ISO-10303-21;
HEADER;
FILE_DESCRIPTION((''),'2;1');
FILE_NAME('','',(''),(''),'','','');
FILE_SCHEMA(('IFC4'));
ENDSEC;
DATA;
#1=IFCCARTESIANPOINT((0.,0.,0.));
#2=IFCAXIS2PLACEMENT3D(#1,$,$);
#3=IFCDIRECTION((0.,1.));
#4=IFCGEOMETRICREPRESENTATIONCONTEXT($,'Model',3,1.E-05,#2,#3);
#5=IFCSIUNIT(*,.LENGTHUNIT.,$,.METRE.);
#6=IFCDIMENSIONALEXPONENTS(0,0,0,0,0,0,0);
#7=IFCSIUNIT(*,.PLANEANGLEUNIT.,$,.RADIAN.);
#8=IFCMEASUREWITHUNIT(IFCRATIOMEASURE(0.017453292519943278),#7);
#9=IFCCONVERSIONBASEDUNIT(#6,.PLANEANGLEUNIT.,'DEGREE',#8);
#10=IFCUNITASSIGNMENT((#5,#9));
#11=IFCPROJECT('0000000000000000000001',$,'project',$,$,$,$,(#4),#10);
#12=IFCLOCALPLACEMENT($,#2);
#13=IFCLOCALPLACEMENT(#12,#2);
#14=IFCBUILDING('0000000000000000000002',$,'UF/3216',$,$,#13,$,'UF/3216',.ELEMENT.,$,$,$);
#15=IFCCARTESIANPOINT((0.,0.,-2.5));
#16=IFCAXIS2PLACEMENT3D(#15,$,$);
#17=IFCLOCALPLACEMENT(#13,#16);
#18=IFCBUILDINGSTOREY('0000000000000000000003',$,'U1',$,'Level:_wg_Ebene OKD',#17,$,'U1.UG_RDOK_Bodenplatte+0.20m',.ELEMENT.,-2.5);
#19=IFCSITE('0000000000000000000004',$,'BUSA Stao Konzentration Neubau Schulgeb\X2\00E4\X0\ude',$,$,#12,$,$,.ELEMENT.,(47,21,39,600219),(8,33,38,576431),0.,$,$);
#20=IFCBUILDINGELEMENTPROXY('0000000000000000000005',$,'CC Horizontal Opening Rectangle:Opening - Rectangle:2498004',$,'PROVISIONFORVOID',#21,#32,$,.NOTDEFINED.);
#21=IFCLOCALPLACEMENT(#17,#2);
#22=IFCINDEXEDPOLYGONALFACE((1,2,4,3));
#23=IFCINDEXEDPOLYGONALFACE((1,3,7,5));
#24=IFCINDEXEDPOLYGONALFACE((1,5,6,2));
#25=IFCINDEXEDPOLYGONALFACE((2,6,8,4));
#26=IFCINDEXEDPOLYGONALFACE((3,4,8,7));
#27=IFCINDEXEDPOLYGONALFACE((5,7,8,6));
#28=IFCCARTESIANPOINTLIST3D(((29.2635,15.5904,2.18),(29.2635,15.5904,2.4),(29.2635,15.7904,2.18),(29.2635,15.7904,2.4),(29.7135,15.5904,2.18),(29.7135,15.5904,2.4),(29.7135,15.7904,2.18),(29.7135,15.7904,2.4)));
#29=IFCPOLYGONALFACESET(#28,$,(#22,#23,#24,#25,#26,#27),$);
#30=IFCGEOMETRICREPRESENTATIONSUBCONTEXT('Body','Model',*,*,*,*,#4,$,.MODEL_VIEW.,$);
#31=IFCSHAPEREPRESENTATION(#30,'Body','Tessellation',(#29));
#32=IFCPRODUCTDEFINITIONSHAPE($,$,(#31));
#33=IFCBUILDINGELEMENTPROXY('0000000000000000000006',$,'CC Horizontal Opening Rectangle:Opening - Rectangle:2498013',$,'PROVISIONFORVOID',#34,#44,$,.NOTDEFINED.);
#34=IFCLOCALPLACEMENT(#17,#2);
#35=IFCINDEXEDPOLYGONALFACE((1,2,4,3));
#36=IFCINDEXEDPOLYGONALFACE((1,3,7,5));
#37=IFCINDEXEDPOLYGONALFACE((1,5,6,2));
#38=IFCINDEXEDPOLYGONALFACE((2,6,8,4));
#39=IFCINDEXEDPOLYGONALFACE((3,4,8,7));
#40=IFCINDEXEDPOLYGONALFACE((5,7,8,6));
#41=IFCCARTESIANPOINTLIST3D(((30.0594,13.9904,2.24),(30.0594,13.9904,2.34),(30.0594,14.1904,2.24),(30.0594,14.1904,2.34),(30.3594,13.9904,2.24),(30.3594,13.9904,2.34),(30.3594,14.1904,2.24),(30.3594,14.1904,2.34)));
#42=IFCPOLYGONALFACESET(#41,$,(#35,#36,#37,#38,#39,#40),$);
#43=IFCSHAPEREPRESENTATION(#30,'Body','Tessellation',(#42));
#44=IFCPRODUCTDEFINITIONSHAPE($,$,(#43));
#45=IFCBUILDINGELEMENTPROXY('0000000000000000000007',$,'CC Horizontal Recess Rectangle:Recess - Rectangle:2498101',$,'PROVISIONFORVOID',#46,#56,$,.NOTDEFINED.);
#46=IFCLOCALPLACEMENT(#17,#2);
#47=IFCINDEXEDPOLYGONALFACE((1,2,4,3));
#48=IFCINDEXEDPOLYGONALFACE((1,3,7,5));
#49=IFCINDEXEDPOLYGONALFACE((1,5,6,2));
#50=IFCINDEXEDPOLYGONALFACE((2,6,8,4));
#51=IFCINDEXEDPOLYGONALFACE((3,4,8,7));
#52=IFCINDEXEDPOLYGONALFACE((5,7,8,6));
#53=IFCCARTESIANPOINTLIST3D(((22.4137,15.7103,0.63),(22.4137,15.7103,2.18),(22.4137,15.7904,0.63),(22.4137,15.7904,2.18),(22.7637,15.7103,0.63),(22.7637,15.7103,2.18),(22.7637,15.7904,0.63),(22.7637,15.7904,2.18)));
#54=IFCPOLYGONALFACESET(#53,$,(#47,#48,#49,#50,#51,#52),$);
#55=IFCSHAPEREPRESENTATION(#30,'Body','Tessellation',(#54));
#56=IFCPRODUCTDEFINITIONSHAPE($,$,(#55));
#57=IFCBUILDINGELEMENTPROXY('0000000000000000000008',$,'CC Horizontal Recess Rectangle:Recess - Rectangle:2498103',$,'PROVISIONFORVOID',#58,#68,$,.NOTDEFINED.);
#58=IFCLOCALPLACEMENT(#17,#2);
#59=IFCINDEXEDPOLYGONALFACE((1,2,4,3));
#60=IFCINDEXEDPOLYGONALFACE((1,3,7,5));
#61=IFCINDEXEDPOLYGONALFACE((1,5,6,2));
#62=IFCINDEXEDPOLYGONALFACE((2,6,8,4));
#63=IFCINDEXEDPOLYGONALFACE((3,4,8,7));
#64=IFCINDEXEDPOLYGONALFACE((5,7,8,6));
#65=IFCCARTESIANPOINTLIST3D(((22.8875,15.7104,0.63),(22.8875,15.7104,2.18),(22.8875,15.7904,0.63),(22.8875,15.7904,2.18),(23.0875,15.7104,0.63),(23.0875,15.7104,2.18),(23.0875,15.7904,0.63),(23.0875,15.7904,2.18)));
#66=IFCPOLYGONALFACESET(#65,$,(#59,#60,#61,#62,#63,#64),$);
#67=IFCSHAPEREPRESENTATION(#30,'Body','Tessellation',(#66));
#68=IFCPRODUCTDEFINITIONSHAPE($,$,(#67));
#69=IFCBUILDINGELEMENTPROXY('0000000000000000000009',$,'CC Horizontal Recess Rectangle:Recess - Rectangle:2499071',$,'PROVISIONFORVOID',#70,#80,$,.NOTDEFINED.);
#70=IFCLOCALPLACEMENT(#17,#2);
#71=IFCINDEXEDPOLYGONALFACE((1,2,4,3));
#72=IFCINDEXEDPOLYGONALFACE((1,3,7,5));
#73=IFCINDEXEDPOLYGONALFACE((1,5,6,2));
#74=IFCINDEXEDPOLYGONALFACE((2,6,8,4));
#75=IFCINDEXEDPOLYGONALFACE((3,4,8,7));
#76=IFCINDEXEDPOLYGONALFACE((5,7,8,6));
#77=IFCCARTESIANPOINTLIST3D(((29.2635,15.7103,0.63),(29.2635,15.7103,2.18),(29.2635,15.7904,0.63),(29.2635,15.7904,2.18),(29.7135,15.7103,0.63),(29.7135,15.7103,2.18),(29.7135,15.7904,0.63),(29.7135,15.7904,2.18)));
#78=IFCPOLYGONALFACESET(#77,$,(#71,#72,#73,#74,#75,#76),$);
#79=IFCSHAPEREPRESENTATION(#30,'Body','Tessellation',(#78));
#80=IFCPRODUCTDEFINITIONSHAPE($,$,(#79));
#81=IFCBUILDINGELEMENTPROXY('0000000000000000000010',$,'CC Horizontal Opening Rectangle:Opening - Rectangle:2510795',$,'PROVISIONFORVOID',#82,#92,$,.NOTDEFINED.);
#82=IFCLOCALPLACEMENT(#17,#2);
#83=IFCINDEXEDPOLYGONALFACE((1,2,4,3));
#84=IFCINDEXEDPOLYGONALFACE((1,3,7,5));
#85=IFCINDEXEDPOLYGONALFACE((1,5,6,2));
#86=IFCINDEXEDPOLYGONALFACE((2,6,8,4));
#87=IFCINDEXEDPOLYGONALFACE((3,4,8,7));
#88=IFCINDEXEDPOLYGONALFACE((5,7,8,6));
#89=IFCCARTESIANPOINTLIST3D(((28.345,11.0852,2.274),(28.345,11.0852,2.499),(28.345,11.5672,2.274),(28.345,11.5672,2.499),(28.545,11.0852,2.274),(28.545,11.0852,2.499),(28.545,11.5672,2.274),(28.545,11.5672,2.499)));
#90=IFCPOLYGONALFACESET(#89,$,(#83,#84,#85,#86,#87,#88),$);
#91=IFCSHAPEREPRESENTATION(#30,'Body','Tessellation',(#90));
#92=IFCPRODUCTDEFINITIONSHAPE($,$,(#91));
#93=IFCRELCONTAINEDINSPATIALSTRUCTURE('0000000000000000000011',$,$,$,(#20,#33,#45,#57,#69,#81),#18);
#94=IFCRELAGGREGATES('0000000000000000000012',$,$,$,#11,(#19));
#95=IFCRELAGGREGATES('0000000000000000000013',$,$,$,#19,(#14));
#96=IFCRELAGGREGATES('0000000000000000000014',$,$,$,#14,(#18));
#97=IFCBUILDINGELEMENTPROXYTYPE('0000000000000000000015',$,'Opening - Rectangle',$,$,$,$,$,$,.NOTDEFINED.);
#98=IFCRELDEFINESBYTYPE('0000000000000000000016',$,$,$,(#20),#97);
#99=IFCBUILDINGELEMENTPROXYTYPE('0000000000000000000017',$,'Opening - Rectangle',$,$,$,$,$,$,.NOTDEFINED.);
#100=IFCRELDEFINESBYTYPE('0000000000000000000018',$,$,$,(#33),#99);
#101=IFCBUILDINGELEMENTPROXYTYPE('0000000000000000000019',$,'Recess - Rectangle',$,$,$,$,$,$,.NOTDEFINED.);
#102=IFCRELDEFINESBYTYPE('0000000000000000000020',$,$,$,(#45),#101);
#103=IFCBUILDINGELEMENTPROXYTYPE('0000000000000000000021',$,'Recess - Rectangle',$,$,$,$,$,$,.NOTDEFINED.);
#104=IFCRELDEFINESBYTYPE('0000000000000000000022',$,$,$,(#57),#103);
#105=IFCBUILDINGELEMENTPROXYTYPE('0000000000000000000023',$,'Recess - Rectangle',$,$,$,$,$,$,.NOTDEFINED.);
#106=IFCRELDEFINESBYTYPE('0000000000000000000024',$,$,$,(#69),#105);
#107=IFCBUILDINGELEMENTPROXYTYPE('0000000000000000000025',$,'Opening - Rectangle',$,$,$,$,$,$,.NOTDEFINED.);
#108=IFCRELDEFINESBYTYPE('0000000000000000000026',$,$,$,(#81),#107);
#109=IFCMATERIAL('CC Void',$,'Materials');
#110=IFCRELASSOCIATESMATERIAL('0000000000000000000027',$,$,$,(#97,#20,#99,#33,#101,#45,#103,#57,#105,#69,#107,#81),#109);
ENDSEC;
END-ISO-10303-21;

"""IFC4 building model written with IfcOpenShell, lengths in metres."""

from ifc_helpers import new_model, entity, si_unit, converted_unit, direction, frame, origin, place, context, subcontext, project, spatial, indexed_curve, outline, extrude, source, transform, mapped, material, type_object, type_shapes, element, save


model = new_model("IFC4")

# Units and contexts
model_context = context("Model", 3, precision=1e-05, world=origin(), true_north=direction((0.0, 1.0)))
body_context = subcontext(model_context, "Body", "Model", "MODEL_VIEW")
ifc_project = project(units=[si_unit("LENGTHUNIT", "METRE"), converted_unit("PLANEANGLEUNIT", "DEGREE", entity("IfcRatioMeasure", 0.017453292519943278), si_unit("PLANEANGLEUNIT", "RADIAN"), dimensions=[0, 0, 0, 0, 0, 0, 0])], contexts=[model_context])

# Site, building, storey
site_placement = place(None, origin())
site = spatial("IfcSite", under=ifc_project, at=site_placement, Name="BUSA Stao Konzentration Neubau Schulgebäude", CompositionType="ELEMENT", RefLatitude=(47, 21, 39, 600219), RefLongitude=(8, 33, 38, 576431), RefElevation=0.0)
building_placement = place(site_placement, origin())
building = spatial("IfcBuilding", under=site, at=building_placement, Name="UF/3216", LongName="UF/3216", CompositionType="ELEMENT")
storey_placement = place(building_placement, frame((0.0, 0.0, -2.5)))
storey = spatial("IfcBuildingStorey", under=building, at=storey_placement, Name="U1", ObjectType="Level:_wg_Ebene OKD", LongName="U1.UG_RDOK_Bodenplatte+0.20m", CompositionType="ELEMENT", Elevation=-2.5)

# Building element proxies
ifc_material_1 = material(Name="CC Void", Category="Materials")
building_element_proxy_type_1 = type_object("IfcBuildingElementProxyType", Name="Opening - Rectangle", PredefinedType="NOTDEFINED", material=ifc_material_1)
shared_shape_1 = source(origin(), body_context, "Body", "SweptSolid", [
    extrude(outline(indexed_curve([(-0.1, -0.225), (0.1, -0.225), (0.1, 0.225), (-0.1, 0.225), (-0.1, -0.225)], self_intersect=False)), frame((0.0, 0.0, -0.32), z_axis=(0.0, 0.0, 1.0), x_axis=(0.0, -1.0, 0.0)), (0.0, 0.0, 1.0), 0.22),
])
type_shapes(building_element_proxy_type_1, [shared_shape_1])
proxy_1_placement = place(storey_placement, frame((29.4885, 15.6904, 2.5)))
element("IfcBuildingElementProxy", 1, at=proxy_1_placement, inside=storey, type_object=building_element_proxy_type_1, material=ifc_material_1, Name="CC Horizontal Opening Rectangle:Opening - Rectangle:2498004", ObjectType="PROVISIONFORVOID", PredefinedType="NOTDEFINED", context=body_context, shape_type="MappedRepresentation", body=[
    mapped(shared_shape_1, transform((0.0, 0.0, 0.0), scale=1.0)),
])
building_element_proxy_type_2 = type_object("IfcBuildingElementProxyType", Name="Opening - Rectangle", PredefinedType="NOTDEFINED", material=ifc_material_1)
shared_shape_2 = source(origin(), body_context, "Body", "SweptSolid", [
    extrude(outline(indexed_curve([(-0.1, -0.15), (0.1, -0.15), (0.1, 0.15), (-0.1, 0.15), (-0.1, -0.15)], self_intersect=False)), frame((0.0, 0.0, -0.26), z_axis=(0.0, 0.0, 1.0), x_axis=(0.0, -1.0, 0.0)), (0.0, 0.0, 1.0), 0.1),
])
type_shapes(building_element_proxy_type_2, [shared_shape_2])
proxy_2_placement = place(storey_placement, frame((30.2094, 14.0904, 2.5)))
element("IfcBuildingElementProxy", 2, at=proxy_2_placement, inside=storey, type_object=building_element_proxy_type_2, material=ifc_material_1, Name="CC Horizontal Opening Rectangle:Opening - Rectangle:2498013", ObjectType="PROVISIONFORVOID", PredefinedType="NOTDEFINED", context=body_context, shape_type="MappedRepresentation", body=[
    mapped(shared_shape_2, transform((0.0, 0.0, 0.0), scale=1.0)),
])
building_element_proxy_type_3 = type_object("IfcBuildingElementProxyType", Name="Recess - Rectangle", PredefinedType="NOTDEFINED", material=ifc_material_1)
shared_shape_3 = source(origin(), body_context, "Body", "SweptSolid", [
    extrude(outline(indexed_curve([(-0.04, -0.175), (0.04, -0.175), (0.04, 0.175), (-0.04, 0.175), (-0.04, -0.175)], self_intersect=False)), frame((0.0, 0.0, -1.87), z_axis=(0.0, 0.0, 1.0), x_axis=(0.0, -1.0, 0.0)), (0.0, 0.0, 1.0), 1.55),
])
type_shapes(building_element_proxy_type_3, [shared_shape_3])
proxy_3_placement = place(storey_placement, frame((22.5887, 15.7503, 2.5)))
element("IfcBuildingElementProxy", 3, at=proxy_3_placement, inside=storey, type_object=building_element_proxy_type_3, material=ifc_material_1, Name="CC Horizontal Recess Rectangle:Recess - Rectangle:2498101", ObjectType="PROVISIONFORVOID", PredefinedType="NOTDEFINED", context=body_context, shape_type="MappedRepresentation", body=[
    mapped(shared_shape_3, transform((0.0, 0.0, 0.0), scale=1.0)),
])
building_element_proxy_type_4 = type_object("IfcBuildingElementProxyType", Name="Recess - Rectangle", PredefinedType="NOTDEFINED", material=ifc_material_1)
shared_shape_4 = source(origin(), body_context, "Body", "SweptSolid", [
    extrude(outline(indexed_curve([(-0.04, -0.1), (0.04, -0.1), (0.04, 0.1), (-0.04, 0.1), (-0.04, -0.1)], self_intersect=False)), frame((0.0, 0.0, -1.87), z_axis=(0.0, 0.0, 1.0), x_axis=(0.0, -1.0, 0.0)), (0.0, 0.0, 1.0), 1.55),
])
type_shapes(building_element_proxy_type_4, [shared_shape_4])
proxy_4_placement = place(storey_placement, frame((22.9875, 15.7504, 2.5)))
element("IfcBuildingElementProxy", 4, at=proxy_4_placement, inside=storey, type_object=building_element_proxy_type_4, material=ifc_material_1, Name="CC Horizontal Recess Rectangle:Recess - Rectangle:2498103", ObjectType="PROVISIONFORVOID", PredefinedType="NOTDEFINED", context=body_context, shape_type="MappedRepresentation", body=[
    mapped(shared_shape_4, transform((0.0, 0.0, 0.0), scale=1.0)),
])
building_element_proxy_type_5 = type_object("IfcBuildingElementProxyType", Name="Recess - Rectangle", PredefinedType="NOTDEFINED", material=ifc_material_1)
shared_shape_5 = source(origin(), body_context, "Body", "SweptSolid", [
    extrude(outline(indexed_curve([(-0.04, -0.225), (0.04, -0.225), (0.04, 0.225), (-0.04, 0.225), (-0.04, -0.225)], self_intersect=False)), frame((0.0, 0.0, -1.87), z_axis=(0.0, 0.0, 1.0), x_axis=(0.0, -1.0, 0.0)), (0.0, 0.0, 1.0), 1.55),
])
type_shapes(building_element_proxy_type_5, [shared_shape_5])
proxy_5_placement = place(storey_placement, frame((29.4885, 15.7503, 2.5)))
element("IfcBuildingElementProxy", 5, at=proxy_5_placement, inside=storey, type_object=building_element_proxy_type_5, material=ifc_material_1, Name="CC Horizontal Recess Rectangle:Recess - Rectangle:2499071", ObjectType="PROVISIONFORVOID", PredefinedType="NOTDEFINED", context=body_context, shape_type="MappedRepresentation", body=[
    mapped(shared_shape_5, transform((0.0, 0.0, 0.0), scale=1.0)),
])
building_element_proxy_type_6 = type_object("IfcBuildingElementProxyType", Name="Opening - Rectangle", PredefinedType="NOTDEFINED", material=ifc_material_1)
shared_shape_6 = source(origin(), body_context, "Body", "SweptSolid", [
    extrude(outline(indexed_curve([(-0.1, -0.241), (0.1, -0.241), (0.1, 0.241), (-0.1, 0.241), (-0.1, -0.241)], self_intersect=False)), frame((0.0, 0.0, -0.226), z_axis=(0.0, 0.0, 1.0), x_axis=(0.0, -1.0, 0.0)), (0.0, 0.0, 1.0), 0.225),
])
type_shapes(building_element_proxy_type_6, [shared_shape_6])
proxy_6_placement = place(storey_placement, frame((28.445, 11.3262, 2.5), z_axis=(0.0, 0.0, 1.0), x_axis=(0.0, 1.0, 0.0)))
element("IfcBuildingElementProxy", 6, at=proxy_6_placement, inside=storey, type_object=building_element_proxy_type_6, material=ifc_material_1, Name="CC Horizontal Opening Rectangle:Opening - Rectangle:2510795", ObjectType="PROVISIONFORVOID", PredefinedType="NOTDEFINED", context=body_context, shape_type="MappedRepresentation", body=[
    mapped(shared_shape_6, transform((0.0, 0.0, 0.0), scale=1.0)),
])

save(model, "model.ifc")
